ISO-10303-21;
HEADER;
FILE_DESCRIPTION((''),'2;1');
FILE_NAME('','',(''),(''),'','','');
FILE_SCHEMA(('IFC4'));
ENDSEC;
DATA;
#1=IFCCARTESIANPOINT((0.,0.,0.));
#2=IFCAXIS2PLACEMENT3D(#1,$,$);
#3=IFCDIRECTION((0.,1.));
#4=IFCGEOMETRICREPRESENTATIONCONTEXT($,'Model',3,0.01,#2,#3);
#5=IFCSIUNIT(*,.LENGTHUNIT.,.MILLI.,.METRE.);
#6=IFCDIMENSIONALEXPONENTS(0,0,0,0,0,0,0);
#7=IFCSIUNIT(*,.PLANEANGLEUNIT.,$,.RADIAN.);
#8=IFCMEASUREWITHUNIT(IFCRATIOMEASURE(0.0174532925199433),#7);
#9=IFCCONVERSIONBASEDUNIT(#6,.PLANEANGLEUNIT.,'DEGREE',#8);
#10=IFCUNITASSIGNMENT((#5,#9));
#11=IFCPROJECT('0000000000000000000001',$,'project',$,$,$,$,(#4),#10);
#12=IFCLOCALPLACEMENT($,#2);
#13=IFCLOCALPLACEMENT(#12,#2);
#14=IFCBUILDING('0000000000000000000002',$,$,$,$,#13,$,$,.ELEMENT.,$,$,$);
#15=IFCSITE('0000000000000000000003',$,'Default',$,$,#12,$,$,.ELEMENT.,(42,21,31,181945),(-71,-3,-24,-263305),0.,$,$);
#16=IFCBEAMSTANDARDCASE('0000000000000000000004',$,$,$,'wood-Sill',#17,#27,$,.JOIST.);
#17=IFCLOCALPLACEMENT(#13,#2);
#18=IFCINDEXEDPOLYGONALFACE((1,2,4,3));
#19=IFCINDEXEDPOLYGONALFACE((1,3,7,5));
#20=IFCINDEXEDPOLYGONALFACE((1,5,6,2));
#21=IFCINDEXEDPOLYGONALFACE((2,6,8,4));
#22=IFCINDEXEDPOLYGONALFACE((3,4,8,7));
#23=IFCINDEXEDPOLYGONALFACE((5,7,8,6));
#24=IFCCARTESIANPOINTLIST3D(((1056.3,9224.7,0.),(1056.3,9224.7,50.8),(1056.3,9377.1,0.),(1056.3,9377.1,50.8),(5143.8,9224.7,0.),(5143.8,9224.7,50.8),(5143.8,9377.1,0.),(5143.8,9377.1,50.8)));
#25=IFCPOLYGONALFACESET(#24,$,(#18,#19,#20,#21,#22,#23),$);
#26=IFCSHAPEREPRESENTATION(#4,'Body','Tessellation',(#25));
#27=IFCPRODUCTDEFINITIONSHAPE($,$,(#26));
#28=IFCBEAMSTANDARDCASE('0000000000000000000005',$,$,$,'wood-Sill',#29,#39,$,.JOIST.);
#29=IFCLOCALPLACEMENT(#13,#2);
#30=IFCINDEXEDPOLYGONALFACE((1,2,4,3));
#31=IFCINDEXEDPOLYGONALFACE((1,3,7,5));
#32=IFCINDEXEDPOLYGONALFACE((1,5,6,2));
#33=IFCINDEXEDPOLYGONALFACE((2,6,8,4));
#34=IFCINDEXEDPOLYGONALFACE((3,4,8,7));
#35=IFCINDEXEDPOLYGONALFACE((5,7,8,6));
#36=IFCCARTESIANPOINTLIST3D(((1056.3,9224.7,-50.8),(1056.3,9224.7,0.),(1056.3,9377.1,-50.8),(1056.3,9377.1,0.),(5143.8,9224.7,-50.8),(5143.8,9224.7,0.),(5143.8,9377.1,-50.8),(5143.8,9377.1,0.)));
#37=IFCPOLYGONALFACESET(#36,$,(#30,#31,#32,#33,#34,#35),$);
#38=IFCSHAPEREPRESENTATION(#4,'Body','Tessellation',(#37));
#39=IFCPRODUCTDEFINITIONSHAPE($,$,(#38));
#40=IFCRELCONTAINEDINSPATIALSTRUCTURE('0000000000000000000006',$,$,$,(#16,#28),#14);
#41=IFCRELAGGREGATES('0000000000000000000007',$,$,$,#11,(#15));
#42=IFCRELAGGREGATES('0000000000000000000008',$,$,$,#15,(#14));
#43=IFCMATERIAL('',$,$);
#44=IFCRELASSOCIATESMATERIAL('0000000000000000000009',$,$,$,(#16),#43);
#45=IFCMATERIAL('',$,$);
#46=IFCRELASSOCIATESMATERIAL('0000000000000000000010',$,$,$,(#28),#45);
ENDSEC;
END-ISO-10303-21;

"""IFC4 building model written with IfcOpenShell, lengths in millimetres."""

from ifc_helpers import new_model, entity, si_unit, converted_unit, direction, frame, origin, place, context, project, spatial, rectangle, extrude, material, element, save


model = new_model("IFC4")

# Units and contexts
model_context = context("Model", 3, precision=0.01, world=origin(), true_north=direction((0.0, 1.0)))
ifc_project = project(units=[si_unit("LENGTHUNIT", "METRE", prefix="MILLI"), converted_unit("PLANEANGLEUNIT", "DEGREE", entity("IfcRatioMeasure", 0.0174532925199433), si_unit("PLANEANGLEUNIT", "RADIAN"), dimensions=[0, 0, 0, 0, 0, 0, 0])], contexts=[model_context])

# Site, building
site_placement = place(None, origin())
site = spatial("IfcSite", under=ifc_project, at=site_placement, Name="Default", CompositionType="ELEMENT", RefLatitude=(42, 21, 31, 181945), RefLongitude=(-71, -3, -24, -263305), RefElevation=0.0)
building_placement = place(site_placement, origin())
building = spatial("IfcBuilding", under=site, at=building_placement, CompositionType="ELEMENT")

# Shared definitions
placement_1 = place(building_placement, origin())
placement_2 = place(placement_1, frame((3100.1, 7257.2, 0.0), z_axis=(0.0, 0.0, 1.0), x_axis=(0.0, 1.0, 0.0)))

# Beams
ifc_material_1 = material(Name="")
beam_1_placement = place(placement_2, frame((2043.8, 0.0, 0.0), z_axis=(0.0, 0.0, 1.0), x_axis=(0.0, 1.0, 0.0)))
element("IfcBeamStandardCase", 1, at=beam_1_placement, inside=building, material=ifc_material_1, ObjectType="wood-Sill", PredefinedType="JOIST", context=model_context, shape_type="SweptSolid", body=[
    extrude(rectangle(XDim=4087.5, YDim=152.4), origin(), (0.0, 0.0, 1.0), 50.8),
])
ifc_material_2 = material(Name="")
beam_2_placement = place(placement_2, frame((2043.8, 0.0, -50.8), z_axis=(0.0, 0.0, 1.0), x_axis=(0.0, 1.0, 0.0)))
element("IfcBeamStandardCase", 2, at=beam_2_placement, inside=building, material=ifc_material_2, ObjectType="wood-Sill", PredefinedType="JOIST", context=model_context, shape_type="SweptSolid", body=[
    extrude(rectangle(XDim=4087.5, YDim=152.4), origin(), (0.0, 0.0, 1.0), 50.8),
])

save(model, "model.ifc")
